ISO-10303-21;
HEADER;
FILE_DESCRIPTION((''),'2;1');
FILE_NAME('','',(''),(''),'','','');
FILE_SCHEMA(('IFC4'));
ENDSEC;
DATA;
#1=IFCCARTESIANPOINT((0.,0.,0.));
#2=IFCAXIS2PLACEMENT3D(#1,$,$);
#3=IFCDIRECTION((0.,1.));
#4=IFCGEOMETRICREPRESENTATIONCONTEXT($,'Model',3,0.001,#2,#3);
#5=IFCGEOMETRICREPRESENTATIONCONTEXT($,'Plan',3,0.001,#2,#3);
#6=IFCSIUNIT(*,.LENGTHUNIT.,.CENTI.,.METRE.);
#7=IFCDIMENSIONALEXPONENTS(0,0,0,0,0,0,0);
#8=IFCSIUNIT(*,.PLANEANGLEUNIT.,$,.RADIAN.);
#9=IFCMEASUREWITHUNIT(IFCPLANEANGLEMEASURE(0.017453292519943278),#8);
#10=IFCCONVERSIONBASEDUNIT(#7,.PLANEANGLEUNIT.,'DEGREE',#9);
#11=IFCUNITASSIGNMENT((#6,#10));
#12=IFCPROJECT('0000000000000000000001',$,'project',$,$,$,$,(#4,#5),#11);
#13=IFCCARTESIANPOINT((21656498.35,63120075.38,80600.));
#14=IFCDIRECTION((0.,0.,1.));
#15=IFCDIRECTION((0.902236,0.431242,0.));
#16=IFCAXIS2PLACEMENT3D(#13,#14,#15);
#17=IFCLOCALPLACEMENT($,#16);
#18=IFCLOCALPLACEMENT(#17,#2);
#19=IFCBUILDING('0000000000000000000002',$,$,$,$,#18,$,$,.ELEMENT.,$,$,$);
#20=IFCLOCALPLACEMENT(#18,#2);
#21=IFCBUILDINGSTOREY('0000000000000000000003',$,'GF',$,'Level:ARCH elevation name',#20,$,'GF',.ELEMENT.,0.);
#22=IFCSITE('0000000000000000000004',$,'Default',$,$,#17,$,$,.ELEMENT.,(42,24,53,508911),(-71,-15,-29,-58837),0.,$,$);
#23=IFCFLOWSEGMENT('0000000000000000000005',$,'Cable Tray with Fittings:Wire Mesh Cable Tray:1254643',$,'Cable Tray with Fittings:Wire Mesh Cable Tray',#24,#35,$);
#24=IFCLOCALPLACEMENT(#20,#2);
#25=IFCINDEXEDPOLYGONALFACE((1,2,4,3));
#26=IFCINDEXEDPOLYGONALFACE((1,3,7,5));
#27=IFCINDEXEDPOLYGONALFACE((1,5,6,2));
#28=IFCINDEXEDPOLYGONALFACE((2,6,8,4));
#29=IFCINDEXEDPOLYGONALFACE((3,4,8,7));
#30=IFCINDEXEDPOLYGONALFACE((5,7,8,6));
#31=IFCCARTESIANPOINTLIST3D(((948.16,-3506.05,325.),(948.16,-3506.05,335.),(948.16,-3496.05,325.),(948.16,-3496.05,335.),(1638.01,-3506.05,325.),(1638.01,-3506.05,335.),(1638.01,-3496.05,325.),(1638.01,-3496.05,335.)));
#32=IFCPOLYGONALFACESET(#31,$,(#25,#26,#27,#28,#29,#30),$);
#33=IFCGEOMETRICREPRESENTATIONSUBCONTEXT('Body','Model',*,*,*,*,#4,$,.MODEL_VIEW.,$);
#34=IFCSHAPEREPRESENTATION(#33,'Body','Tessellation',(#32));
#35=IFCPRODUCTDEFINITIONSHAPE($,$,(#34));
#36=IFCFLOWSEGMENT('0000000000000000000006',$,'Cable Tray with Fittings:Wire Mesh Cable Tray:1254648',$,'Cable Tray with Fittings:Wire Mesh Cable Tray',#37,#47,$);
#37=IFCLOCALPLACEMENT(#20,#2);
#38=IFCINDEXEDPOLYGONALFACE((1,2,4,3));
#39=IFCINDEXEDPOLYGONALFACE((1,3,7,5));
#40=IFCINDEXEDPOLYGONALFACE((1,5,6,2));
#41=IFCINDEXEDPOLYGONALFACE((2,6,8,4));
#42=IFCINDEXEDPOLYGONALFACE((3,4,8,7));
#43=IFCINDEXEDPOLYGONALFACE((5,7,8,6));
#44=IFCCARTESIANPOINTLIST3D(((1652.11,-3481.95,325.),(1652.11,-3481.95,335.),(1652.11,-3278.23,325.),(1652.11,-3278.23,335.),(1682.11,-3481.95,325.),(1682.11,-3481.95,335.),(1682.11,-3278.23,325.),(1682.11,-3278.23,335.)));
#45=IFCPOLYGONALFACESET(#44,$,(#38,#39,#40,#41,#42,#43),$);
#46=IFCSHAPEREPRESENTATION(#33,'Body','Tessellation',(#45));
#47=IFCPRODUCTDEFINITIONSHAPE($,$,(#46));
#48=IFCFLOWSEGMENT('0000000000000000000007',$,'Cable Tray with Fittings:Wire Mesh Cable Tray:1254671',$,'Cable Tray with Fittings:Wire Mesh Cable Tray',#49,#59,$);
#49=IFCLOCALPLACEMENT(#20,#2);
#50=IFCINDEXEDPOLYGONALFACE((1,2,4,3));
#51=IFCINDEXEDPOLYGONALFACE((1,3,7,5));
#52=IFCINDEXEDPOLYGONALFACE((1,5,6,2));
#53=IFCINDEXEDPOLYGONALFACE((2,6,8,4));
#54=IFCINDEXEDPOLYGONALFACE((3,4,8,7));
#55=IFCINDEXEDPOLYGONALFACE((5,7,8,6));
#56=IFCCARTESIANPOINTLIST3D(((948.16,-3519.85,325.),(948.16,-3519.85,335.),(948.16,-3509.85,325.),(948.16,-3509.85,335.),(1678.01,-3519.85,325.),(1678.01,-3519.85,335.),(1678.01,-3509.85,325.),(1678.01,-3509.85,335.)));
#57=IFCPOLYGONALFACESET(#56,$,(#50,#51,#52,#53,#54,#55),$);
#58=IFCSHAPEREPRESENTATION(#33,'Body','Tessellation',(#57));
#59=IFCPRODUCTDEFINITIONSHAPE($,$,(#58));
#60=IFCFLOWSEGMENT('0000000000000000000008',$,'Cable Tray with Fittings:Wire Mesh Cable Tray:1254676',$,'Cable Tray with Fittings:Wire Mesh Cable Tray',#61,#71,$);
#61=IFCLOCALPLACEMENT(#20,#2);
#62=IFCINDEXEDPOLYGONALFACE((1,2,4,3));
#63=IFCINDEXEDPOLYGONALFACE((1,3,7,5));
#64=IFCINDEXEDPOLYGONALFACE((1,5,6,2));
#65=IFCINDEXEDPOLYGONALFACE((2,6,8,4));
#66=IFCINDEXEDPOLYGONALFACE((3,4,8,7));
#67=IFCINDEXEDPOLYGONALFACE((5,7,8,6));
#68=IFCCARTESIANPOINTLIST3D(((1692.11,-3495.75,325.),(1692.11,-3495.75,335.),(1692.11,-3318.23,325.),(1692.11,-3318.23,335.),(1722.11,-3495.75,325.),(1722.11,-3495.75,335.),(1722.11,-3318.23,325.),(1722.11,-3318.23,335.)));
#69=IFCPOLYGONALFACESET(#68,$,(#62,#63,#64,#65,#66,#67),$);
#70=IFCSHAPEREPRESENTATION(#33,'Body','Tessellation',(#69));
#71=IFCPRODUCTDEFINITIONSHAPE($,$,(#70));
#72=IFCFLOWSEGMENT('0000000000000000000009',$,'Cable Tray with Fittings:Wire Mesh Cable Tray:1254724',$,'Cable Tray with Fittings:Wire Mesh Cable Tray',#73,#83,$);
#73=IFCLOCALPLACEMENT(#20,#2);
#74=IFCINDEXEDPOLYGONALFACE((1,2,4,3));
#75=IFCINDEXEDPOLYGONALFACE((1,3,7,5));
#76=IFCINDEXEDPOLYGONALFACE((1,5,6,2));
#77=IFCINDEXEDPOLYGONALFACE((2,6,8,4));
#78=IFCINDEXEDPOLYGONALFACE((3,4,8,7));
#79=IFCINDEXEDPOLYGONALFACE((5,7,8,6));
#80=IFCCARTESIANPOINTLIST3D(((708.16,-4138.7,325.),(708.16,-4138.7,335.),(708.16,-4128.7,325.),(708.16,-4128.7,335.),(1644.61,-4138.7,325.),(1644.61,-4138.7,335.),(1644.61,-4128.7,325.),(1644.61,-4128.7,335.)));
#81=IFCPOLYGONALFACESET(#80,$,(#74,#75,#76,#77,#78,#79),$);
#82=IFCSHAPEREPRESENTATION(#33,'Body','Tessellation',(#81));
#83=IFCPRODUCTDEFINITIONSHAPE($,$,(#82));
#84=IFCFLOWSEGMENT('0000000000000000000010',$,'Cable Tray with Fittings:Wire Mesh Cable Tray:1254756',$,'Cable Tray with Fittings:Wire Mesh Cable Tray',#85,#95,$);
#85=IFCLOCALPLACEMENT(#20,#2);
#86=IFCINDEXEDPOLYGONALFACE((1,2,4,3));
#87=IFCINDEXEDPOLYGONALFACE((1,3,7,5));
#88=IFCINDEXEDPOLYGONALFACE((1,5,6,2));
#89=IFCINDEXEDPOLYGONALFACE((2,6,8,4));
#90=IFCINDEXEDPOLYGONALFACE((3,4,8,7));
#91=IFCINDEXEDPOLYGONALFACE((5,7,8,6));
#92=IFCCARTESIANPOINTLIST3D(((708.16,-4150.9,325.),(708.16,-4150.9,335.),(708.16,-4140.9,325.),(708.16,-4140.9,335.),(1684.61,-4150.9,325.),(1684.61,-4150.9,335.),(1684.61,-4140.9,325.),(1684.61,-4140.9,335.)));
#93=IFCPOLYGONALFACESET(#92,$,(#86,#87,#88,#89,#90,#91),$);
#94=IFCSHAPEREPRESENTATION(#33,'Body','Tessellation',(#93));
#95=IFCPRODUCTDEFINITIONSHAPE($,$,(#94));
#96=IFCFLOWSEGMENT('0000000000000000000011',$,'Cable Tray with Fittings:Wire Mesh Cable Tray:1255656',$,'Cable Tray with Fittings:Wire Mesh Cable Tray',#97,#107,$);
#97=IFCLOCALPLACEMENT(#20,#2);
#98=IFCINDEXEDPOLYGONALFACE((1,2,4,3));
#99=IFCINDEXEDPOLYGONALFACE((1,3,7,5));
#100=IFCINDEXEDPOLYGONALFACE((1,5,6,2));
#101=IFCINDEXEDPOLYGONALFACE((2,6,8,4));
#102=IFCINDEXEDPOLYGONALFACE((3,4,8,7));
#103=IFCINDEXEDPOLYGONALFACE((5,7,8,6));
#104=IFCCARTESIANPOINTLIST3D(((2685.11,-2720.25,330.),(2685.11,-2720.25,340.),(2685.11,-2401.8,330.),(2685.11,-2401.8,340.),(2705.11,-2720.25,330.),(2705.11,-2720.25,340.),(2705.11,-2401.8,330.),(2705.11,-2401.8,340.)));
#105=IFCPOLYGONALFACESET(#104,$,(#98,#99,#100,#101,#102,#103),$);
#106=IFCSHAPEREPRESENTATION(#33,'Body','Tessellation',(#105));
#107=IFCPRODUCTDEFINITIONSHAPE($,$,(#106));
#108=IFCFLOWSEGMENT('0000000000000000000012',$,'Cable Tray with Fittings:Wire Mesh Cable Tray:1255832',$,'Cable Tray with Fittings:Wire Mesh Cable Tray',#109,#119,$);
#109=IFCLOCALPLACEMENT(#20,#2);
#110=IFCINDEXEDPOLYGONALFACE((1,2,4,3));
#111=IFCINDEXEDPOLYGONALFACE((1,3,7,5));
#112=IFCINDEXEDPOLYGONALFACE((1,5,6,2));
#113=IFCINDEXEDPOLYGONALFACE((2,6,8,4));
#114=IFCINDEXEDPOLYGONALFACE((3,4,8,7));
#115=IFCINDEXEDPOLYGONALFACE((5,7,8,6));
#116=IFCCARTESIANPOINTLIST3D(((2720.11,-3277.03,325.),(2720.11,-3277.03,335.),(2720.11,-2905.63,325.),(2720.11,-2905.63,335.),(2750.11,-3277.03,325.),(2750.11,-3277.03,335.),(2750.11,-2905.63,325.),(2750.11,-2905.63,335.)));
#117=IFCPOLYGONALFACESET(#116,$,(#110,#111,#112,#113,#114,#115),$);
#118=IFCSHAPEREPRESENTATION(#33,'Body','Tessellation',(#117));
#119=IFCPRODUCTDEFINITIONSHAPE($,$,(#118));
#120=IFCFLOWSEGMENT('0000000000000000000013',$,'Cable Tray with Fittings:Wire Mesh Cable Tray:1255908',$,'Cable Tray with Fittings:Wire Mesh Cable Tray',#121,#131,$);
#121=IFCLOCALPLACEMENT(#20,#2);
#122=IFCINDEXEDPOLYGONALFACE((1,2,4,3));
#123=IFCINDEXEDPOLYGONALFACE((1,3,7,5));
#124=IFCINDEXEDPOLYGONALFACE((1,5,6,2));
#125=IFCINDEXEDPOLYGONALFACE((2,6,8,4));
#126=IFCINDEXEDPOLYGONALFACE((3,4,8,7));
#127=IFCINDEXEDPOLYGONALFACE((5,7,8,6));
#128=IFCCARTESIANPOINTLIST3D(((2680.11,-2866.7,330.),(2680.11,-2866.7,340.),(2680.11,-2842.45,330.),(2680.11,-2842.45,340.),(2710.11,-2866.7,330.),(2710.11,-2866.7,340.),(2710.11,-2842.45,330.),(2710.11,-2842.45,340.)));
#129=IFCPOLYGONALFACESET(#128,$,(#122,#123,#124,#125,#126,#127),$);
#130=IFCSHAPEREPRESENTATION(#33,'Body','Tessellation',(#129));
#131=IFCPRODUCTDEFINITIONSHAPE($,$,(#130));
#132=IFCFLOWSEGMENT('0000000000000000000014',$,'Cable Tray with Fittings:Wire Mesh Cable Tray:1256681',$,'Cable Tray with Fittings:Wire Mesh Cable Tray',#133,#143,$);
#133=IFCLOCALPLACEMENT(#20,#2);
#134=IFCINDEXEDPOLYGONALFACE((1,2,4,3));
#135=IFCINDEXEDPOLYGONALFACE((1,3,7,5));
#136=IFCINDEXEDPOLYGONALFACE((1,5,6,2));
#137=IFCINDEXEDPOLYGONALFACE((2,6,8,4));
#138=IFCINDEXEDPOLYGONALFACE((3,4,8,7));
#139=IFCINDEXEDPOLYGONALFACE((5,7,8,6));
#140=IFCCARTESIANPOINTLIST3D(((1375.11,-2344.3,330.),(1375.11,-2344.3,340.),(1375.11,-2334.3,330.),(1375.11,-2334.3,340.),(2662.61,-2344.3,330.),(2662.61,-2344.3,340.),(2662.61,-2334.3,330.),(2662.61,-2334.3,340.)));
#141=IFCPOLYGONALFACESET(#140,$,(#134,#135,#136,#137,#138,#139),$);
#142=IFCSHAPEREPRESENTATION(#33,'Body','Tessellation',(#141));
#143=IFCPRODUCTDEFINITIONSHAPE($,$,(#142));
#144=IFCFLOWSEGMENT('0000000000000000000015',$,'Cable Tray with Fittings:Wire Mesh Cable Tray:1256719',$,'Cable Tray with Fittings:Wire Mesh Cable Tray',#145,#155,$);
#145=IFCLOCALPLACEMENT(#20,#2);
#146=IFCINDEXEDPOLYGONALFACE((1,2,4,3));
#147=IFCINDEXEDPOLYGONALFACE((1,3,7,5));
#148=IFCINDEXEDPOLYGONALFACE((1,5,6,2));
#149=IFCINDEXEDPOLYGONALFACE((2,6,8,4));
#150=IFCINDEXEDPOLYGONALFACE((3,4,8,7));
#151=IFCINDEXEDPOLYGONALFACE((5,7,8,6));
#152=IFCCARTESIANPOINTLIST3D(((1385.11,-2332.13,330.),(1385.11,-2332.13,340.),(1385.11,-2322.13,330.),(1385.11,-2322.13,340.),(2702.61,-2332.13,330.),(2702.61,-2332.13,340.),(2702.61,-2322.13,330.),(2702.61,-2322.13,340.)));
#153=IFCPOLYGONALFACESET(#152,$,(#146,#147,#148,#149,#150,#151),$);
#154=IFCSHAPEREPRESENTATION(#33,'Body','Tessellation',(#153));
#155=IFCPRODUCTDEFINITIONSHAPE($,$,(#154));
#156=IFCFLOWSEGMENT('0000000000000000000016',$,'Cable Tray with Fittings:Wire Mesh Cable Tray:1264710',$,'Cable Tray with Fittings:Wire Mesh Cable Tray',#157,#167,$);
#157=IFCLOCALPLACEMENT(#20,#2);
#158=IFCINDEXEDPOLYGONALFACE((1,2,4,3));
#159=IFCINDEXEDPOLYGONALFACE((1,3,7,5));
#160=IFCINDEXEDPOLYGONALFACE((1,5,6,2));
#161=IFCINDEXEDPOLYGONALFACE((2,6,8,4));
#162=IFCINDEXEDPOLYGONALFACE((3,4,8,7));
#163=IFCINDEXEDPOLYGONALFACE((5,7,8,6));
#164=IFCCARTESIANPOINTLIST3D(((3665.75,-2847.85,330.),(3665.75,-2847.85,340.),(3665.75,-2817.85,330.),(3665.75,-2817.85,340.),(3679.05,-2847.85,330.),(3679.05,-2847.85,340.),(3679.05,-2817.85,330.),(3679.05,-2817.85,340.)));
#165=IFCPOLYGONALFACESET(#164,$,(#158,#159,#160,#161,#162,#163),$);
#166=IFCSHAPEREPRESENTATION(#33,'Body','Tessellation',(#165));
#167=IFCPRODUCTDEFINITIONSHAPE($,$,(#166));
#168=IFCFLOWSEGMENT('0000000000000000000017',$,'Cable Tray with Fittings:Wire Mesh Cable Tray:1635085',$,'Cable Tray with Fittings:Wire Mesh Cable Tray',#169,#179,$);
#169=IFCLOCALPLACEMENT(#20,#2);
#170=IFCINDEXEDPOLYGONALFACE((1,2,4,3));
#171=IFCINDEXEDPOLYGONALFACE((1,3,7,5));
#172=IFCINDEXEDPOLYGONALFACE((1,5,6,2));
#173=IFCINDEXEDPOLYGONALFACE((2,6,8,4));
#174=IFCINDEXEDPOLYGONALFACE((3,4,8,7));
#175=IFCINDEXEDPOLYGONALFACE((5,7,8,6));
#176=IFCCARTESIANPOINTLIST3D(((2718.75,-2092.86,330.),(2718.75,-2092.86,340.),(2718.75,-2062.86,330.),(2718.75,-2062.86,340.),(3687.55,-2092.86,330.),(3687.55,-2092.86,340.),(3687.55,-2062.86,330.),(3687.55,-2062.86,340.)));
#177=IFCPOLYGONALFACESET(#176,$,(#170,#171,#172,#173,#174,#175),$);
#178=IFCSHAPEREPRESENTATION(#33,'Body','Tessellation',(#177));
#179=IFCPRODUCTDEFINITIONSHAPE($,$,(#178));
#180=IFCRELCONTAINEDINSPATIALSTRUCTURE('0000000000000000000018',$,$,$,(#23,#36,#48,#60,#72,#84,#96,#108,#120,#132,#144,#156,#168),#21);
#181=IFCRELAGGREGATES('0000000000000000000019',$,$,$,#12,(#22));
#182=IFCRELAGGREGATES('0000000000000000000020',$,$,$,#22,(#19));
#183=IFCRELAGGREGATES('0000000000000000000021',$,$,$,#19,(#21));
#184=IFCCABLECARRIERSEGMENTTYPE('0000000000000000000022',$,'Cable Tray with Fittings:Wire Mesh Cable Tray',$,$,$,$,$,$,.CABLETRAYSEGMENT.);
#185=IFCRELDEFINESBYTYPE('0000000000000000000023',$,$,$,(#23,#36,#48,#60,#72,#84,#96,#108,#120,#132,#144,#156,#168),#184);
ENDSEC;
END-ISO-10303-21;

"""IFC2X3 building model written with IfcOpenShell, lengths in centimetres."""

from ifc_helpers import new_model, entity, si_unit, converted_unit, direction, frame, frame_2d, origin, origin_2d_with_axis, place, context, subcontext, project, spatial, rectangle, extrude, type_object, element, save


model = new_model("IFC2X3")

# Units and contexts
model_context = context("Model", 3, precision=0.001, world=origin(), true_north=direction((0.0, 1.0)))
plan_context = context("Plan", 3, precision=0.001, world=origin(), true_north=direction((0.0, 1.0)))
body_context = subcontext(model_context, "Body", "Model", "MODEL_VIEW")
ifc_project = project(units=[si_unit("LENGTHUNIT", "METRE", prefix="CENTI"), converted_unit("PLANEANGLEUNIT", "DEGREE", entity("IfcPlaneAngleMeasure", 0.017453292519943278), si_unit("PLANEANGLEUNIT", "RADIAN"), dimensions=[0, 0, 0, 0, 0, 0, 0])], contexts=[model_context, plan_context])

# Site, building, storey
site_placement = place(None, frame((21656498.35, 63120075.38, 80600.0), z_axis=(0.0, 0.0, 1.0), x_axis=(0.902236, 0.431242, 0.0)))
site = spatial("IfcSite", under=ifc_project, at=site_placement, Name="Default", CompositionType="ELEMENT", RefLatitude=(42, 24, 53, 508911), RefLongitude=(-71, -15, -29, -58837), RefElevation=0.0)
building_placement = place(site_placement, origin())
building = spatial("IfcBuilding", under=site, at=building_placement, CompositionType="ELEMENT")
storey_placement = place(building_placement, origin())
storey = spatial("IfcBuildingStorey", under=building, at=storey_placement, Name="GF", ObjectType="Level:ARCH elevation name", LongName="GF", CompositionType="ELEMENT", Elevation=0.0)

# Flow segments
cable_carrier_segment_type_1 = type_object("IfcCableCarrierSegmentType", Name="Cable Tray with Fittings:Wire Mesh Cable Tray", PredefinedType="CABLETRAYSEGMENT")
flow_segment_1_placement = place(storey_placement, origin())
element("IfcFlowSegment", 1, at=flow_segment_1_placement, inside=storey, type_object=cable_carrier_segment_type_1, Name="Cable Tray with Fittings:Wire Mesh Cable Tray:1254643", ObjectType="Cable Tray with Fittings:Wire Mesh Cable Tray", context=body_context, shape_type="SweptSolid", body=[
    extrude(rectangle(XDim=689.85, YDim=10.0, at=frame_2d((0.0, 0.0), x_axis=(1.0, 0.0))), frame((1293.09, -3501.05, 325.0), z_axis=(0.0, 0.0, 1.0), x_axis=(-1.0, 0.0, 0.0)), (0.0, 0.0, 1.0), 10.0),
])
flow_segment_2_placement = place(storey_placement, origin())
element("IfcFlowSegment", 2, at=flow_segment_2_placement, inside=storey, type_object=cable_carrier_segment_type_1, Name="Cable Tray with Fittings:Wire Mesh Cable Tray:1254648", ObjectType="Cable Tray with Fittings:Wire Mesh Cable Tray", context=body_context, shape_type="SweptSolid", body=[
    extrude(rectangle(XDim=203.73, YDim=30.0, at=origin_2d_with_axis()), frame((1667.11, -3380.09, 325.0), z_axis=(0.0, 0.0, 1.0), x_axis=(0.0, -1.0, 0.0)), (0.0, 0.0, 1.0), 10.0),
])
flow_segment_3_placement = place(storey_placement, origin())
element("IfcFlowSegment", 3, at=flow_segment_3_placement, inside=storey, type_object=cable_carrier_segment_type_1, Name="Cable Tray with Fittings:Wire Mesh Cable Tray:1254671", ObjectType="Cable Tray with Fittings:Wire Mesh Cable Tray", context=body_context, shape_type="SweptSolid", body=[
    extrude(rectangle(XDim=729.85, YDim=10.0, at=frame_2d((0.0, 0.0), x_axis=(1.0, 0.0))), frame((1313.09, -3514.85, 325.0), z_axis=(0.0, 0.0, 1.0), x_axis=(-1.0, 0.0, 0.0)), (0.0, 0.0, 1.0), 10.0),
])
flow_segment_4_placement = place(storey_placement, origin())
element("IfcFlowSegment", 4, at=flow_segment_4_placement, inside=storey, type_object=cable_carrier_segment_type_1, Name="Cable Tray with Fittings:Wire Mesh Cable Tray:1254676", ObjectType="Cable Tray with Fittings:Wire Mesh Cable Tray", context=body_context, shape_type="SweptSolid", body=[
    extrude(rectangle(XDim=177.53, YDim=30.0, at=frame_2d((0.0, 0.0), x_axis=(1.0, 0.0))), frame((1707.11, -3406.99, 325.0), z_axis=(0.0, 0.0, 1.0), x_axis=(0.0, -1.0, 0.0)), (0.0, 0.0, 1.0), 10.0),
])
flow_segment_5_placement = place(storey_placement, origin())
element("IfcFlowSegment", 5, at=flow_segment_5_placement, inside=storey, type_object=cable_carrier_segment_type_1, Name="Cable Tray with Fittings:Wire Mesh Cable Tray:1254724", ObjectType="Cable Tray with Fittings:Wire Mesh Cable Tray", context=body_context, shape_type="SweptSolid", body=[
    extrude(rectangle(XDim=936.45, YDim=10.0, at=frame_2d((0.0, 0.0), x_axis=(1.0, 0.0))), frame((1176.39, -4133.7, 325.0), z_axis=(0.0, 0.0, 1.0), x_axis=(-1.0, 0.0, 0.0)), (0.0, 0.0, 1.0), 10.0),
])
flow_segment_6_placement = place(storey_placement, origin())
element("IfcFlowSegment", 6, at=flow_segment_6_placement, inside=storey, type_object=cable_carrier_segment_type_1, Name="Cable Tray with Fittings:Wire Mesh Cable Tray:1254756", ObjectType="Cable Tray with Fittings:Wire Mesh Cable Tray", context=body_context, shape_type="SweptSolid", body=[
    extrude(rectangle(XDim=976.45, YDim=10.0, at=origin_2d_with_axis()), frame((1196.39, -4145.9, 325.0), z_axis=(0.0, 0.0, 1.0), x_axis=(-1.0, 0.0, 0.0)), (0.0, 0.0, 1.0), 10.0),
])
flow_segment_7_placement = place(storey_placement, origin())
element("IfcFlowSegment", 7, at=flow_segment_7_placement, inside=storey, type_object=cable_carrier_segment_type_1, Name="Cable Tray with Fittings:Wire Mesh Cable Tray:1255656", ObjectType="Cable Tray with Fittings:Wire Mesh Cable Tray", context=body_context, shape_type="SweptSolid", body=[
    extrude(rectangle(XDim=318.45, YDim=20.0, at=origin_2d_with_axis()), frame((2695.11, -2561.02, 330.0), z_axis=(0.0, 0.0, 1.0), x_axis=(0.0, -1.0, 0.0)), (0.0, 0.0, 1.0), 10.0),
])
flow_segment_8_placement = place(storey_placement, origin())
element("IfcFlowSegment", 8, at=flow_segment_8_placement, inside=storey, type_object=cable_carrier_segment_type_1, Name="Cable Tray with Fittings:Wire Mesh Cable Tray:1255832", ObjectType="Cable Tray with Fittings:Wire Mesh Cable Tray", context=body_context, shape_type="SweptSolid", body=[
    extrude(rectangle(XDim=371.4, YDim=30.0, at=frame_2d((0.0, 0.0), x_axis=(1.0, 0.0))), frame((2735.11, -3091.33, 325.0), z_axis=(0.0, 0.0, 1.0), x_axis=(0.0, 1.0, 0.0)), (0.0, 0.0, 1.0), 10.0),
])
flow_segment_9_placement = place(storey_placement, origin())
element("IfcFlowSegment", 9, at=flow_segment_9_placement, inside=storey, type_object=cable_carrier_segment_type_1, Name="Cable Tray with Fittings:Wire Mesh Cable Tray:1255908", ObjectType="Cable Tray with Fittings:Wire Mesh Cable Tray", context=body_context, shape_type="SweptSolid", body=[
    extrude(rectangle(XDim=24.25, YDim=30.0, at=origin_2d_with_axis()), frame((2695.11, -2854.57, 330.0), z_axis=(0.0, 0.0, 1.0), x_axis=(0.0, 1.0, 0.0)), (0.0, 0.0, 1.0), 10.0),
])
flow_segment_10_placement = place(storey_placement, origin())
element("IfcFlowSegment", 10, at=flow_segment_10_placement, inside=storey, type_object=cable_carrier_segment_type_1, Name="Cable Tray with Fittings:Wire Mesh Cable Tray:1256681", ObjectType="Cable Tray with Fittings:Wire Mesh Cable Tray", context=body_context, shape_type="SweptSolid", body=[
    extrude(rectangle(XDim=1287.5, YDim=10.0, at=frame_2d((0.0, 0.0), x_axis=(1.0, 0.0))), frame((2018.86, -2339.3, 330.0), z_axis=(0.0, 0.0, 1.0), x_axis=(-1.0, 0.0, 0.0)), (0.0, 0.0, 1.0), 10.0),
])
flow_segment_11_placement = place(storey_placement, origin())
element("IfcFlowSegment", 11, at=flow_segment_11_placement, inside=storey, type_object=cable_carrier_segment_type_1, Name="Cable Tray with Fittings:Wire Mesh Cable Tray:1256719", ObjectType="Cable Tray with Fittings:Wire Mesh Cable Tray", context=body_context, shape_type="SweptSolid", body=[
    extrude(rectangle(XDim=1317.5, YDim=10.0, at=frame_2d((0.0, 0.0), x_axis=(1.0, 0.0))), frame((2043.86, -2327.13, 330.0), z_axis=(0.0, 0.0, 1.0), x_axis=(-1.0, 0.0, 0.0)), (0.0, 0.0, 1.0), 10.0),
])
flow_segment_12_placement = place(storey_placement, origin())
element("IfcFlowSegment", 12, at=flow_segment_12_placement, inside=storey, type_object=cable_carrier_segment_type_1, Name="Cable Tray with Fittings:Wire Mesh Cable Tray:1264710", ObjectType="Cable Tray with Fittings:Wire Mesh Cable Tray", context=body_context, shape_type="SweptSolid", body=[
    extrude(rectangle(XDim=13.29, YDim=30.0, at=origin_2d_with_axis()), frame((3672.4, -2832.85, 330.0), z_axis=(0.0, 0.0, 1.0), x_axis=(-1.0, 0.0, 0.0)), (0.0, 0.0, 1.0), 10.0),
])
flow_segment_13_placement = place(storey_placement, origin())
element("IfcFlowSegment", 13, at=flow_segment_13_placement, inside=storey, type_object=cable_carrier_segment_type_1, Name="Cable Tray with Fittings:Wire Mesh Cable Tray:1635085", ObjectType="Cable Tray with Fittings:Wire Mesh Cable Tray", context=body_context, shape_type="SweptSolid", body=[
    extrude(rectangle(XDim=968.8, YDim=30.0, at=frame_2d((0.0, 0.0), x_axis=(1.0, 0.0))), frame((3203.15, -2077.86, 330.0), z_axis=(0.0, 0.0, 1.0), x_axis=(-1.0, 0.0, 0.0)), (0.0, 0.0, 1.0), 10.0),
])

save(model, "model.ifc")
